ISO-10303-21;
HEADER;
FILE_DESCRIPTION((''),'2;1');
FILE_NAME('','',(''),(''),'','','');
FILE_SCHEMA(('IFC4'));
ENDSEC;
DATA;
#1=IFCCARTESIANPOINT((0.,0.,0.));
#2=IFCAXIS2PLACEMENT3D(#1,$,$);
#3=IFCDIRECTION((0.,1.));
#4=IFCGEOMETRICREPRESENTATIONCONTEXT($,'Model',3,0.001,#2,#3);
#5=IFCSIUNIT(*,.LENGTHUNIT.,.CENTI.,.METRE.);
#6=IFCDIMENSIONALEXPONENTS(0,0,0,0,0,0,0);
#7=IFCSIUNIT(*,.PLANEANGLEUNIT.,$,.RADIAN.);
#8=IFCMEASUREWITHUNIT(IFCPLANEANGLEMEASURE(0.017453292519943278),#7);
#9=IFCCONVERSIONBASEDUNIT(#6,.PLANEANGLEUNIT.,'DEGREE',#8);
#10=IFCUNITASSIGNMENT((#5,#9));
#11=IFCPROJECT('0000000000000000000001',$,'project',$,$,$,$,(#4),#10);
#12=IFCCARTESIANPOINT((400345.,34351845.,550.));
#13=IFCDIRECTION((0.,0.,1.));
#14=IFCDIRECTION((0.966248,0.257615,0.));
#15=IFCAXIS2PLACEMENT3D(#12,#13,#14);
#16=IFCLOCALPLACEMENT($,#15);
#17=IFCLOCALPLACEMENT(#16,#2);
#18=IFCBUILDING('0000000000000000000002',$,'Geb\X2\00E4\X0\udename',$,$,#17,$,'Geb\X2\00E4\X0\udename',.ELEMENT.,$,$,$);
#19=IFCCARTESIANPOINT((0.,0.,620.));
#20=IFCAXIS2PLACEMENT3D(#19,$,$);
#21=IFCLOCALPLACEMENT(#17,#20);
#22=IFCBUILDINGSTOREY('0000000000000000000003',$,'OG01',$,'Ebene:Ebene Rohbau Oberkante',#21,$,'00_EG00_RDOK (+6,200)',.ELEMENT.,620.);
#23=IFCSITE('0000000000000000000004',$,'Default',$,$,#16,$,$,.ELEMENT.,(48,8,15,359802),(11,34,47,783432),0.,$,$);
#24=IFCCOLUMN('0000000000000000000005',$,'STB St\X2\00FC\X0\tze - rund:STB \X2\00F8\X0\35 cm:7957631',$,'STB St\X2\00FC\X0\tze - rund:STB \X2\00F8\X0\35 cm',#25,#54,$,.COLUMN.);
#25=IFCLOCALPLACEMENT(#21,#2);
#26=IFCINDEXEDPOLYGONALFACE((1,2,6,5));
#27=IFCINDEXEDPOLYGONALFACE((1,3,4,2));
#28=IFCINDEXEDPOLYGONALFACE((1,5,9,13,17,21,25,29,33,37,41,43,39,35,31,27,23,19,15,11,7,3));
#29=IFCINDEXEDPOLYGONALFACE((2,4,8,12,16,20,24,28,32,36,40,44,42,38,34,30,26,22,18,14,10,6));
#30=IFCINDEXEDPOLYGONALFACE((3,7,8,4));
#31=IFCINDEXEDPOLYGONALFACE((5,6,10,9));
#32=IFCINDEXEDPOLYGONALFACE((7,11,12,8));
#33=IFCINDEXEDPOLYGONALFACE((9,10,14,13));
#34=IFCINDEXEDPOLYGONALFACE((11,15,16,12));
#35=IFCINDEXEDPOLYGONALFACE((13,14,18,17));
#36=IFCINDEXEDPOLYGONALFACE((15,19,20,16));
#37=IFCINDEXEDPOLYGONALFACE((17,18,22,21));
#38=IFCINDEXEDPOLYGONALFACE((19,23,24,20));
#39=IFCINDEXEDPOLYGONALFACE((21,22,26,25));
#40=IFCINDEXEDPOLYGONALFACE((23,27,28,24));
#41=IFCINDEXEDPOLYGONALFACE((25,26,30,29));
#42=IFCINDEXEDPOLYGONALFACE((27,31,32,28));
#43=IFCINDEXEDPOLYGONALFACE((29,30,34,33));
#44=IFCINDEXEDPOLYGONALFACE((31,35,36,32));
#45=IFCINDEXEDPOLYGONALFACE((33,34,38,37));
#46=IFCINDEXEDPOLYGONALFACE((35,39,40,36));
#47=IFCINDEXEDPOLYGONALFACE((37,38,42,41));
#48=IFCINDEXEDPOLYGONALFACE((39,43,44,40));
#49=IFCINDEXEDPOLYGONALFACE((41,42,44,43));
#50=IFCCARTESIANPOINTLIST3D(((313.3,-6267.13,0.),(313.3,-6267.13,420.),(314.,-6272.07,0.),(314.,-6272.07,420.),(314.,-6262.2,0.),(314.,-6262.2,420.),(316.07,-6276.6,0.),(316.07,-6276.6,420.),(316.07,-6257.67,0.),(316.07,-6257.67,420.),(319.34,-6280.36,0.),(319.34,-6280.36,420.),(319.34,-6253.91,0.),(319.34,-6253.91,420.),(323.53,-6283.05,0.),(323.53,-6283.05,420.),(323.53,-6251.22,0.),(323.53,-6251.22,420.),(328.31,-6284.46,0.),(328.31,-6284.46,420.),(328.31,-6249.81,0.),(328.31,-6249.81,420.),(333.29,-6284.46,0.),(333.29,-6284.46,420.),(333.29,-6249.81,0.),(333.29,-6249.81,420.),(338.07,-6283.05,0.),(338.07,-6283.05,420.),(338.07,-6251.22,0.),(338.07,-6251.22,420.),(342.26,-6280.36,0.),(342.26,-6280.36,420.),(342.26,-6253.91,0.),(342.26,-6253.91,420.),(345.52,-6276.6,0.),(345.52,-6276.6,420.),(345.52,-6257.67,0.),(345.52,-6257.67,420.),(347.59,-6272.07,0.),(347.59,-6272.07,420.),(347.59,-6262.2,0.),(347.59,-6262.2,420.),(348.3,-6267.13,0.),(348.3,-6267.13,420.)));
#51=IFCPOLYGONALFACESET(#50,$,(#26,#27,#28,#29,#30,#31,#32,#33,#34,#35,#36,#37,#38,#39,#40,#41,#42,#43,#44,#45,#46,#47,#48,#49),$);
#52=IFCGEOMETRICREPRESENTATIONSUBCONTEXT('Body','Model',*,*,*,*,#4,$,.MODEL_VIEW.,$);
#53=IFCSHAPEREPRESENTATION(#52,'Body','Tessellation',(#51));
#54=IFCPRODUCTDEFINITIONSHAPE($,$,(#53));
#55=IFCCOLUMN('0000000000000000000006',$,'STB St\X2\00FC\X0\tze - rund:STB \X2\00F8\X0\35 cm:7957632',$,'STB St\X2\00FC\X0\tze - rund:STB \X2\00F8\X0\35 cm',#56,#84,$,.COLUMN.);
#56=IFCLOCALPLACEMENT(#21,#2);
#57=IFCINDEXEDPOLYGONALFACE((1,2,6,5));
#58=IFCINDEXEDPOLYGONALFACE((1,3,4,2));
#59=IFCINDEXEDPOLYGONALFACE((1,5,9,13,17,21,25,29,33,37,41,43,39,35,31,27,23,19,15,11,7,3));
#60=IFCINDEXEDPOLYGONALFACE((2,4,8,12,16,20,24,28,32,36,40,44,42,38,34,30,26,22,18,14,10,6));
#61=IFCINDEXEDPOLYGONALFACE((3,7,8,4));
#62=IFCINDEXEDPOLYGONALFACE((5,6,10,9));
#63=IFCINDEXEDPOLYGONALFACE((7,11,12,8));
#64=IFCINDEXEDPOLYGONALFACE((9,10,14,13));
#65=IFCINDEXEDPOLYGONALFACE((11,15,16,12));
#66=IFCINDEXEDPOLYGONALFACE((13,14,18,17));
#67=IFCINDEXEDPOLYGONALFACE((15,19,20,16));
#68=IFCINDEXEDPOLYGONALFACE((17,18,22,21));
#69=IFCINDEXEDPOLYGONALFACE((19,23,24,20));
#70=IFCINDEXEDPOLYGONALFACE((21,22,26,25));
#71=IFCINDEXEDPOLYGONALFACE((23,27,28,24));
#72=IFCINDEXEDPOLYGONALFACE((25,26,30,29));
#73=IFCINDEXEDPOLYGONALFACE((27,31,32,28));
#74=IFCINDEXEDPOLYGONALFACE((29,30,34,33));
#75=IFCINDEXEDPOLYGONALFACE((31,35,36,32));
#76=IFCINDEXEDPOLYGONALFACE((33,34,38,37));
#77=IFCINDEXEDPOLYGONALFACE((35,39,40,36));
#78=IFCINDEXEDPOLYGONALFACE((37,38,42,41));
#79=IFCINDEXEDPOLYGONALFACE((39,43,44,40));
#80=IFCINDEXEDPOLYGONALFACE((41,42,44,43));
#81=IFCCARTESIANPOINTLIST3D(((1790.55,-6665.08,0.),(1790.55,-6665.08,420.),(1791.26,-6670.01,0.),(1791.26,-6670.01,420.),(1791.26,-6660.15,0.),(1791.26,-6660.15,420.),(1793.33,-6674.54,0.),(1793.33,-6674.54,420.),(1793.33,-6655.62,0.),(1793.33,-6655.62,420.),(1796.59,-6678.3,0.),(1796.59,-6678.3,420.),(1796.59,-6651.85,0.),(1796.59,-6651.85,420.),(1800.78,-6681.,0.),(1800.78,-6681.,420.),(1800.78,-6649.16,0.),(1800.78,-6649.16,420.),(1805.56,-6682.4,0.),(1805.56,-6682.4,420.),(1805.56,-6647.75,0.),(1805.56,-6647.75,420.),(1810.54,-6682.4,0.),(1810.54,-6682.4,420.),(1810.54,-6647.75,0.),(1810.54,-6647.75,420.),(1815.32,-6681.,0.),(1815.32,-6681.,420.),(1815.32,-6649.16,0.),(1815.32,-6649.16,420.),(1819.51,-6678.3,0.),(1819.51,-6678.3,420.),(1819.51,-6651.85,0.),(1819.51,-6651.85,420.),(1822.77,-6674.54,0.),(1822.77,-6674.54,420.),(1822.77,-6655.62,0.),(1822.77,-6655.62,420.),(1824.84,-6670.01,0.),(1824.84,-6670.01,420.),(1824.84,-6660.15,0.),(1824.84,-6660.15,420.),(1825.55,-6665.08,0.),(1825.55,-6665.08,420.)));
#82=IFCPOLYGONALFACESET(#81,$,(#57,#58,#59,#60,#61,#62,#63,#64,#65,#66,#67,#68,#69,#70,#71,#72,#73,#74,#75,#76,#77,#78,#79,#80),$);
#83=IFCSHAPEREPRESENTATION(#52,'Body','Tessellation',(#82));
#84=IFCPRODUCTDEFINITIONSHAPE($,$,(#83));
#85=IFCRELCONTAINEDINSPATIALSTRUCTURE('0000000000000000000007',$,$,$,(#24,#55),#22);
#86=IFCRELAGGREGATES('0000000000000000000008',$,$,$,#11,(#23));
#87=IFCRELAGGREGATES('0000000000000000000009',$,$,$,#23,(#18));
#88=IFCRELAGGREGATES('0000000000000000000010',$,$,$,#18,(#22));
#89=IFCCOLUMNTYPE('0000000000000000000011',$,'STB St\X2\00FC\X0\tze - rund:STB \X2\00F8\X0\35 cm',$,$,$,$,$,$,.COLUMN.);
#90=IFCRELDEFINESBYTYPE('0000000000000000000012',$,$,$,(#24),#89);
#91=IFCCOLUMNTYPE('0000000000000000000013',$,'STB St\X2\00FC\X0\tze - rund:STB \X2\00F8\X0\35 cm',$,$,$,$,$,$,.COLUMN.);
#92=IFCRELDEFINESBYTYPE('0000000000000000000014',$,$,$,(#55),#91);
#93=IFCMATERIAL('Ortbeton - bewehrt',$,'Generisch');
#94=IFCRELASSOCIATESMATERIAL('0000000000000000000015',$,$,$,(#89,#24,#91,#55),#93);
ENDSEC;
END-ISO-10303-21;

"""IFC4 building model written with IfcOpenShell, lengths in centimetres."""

from ifc_helpers import new_model, entity, si_unit, converted_unit, direction, frame, origin, place, context, subcontext, project, spatial, arc, indexed_curve, outline, extrude, source, transform, mapped, material, type_object, type_shapes, element, save


model = new_model("IFC4")

# Units and contexts
model_context = context("Model", 3, precision=0.001, world=origin(), true_north=direction((0.0, 1.0)))
body_context = subcontext(model_context, "Body", "Model", "MODEL_VIEW")
ifc_project = project(units=[si_unit("LENGTHUNIT", "METRE", prefix="CENTI"), converted_unit("PLANEANGLEUNIT", "DEGREE", entity("IfcPlaneAngleMeasure", 0.017453292519943278), si_unit("PLANEANGLEUNIT", "RADIAN"), dimensions=[0, 0, 0, 0, 0, 0, 0])], contexts=[model_context])

# Site, building, storey
site_placement = place(None, frame((400345.0, 34351845.0, 550.0), z_axis=(0.0, 0.0, 1.0), x_axis=(0.966248, 0.257615, 0.0)))
site = spatial("IfcSite", under=ifc_project, at=site_placement, Name="Default", CompositionType="ELEMENT", RefLatitude=(48, 8, 15, 359802), RefLongitude=(11, 34, 47, 783432), RefElevation=0.0)
building_placement = place(site_placement, origin())
building = spatial("IfcBuilding", under=site, at=building_placement, Name="Gebäudename", LongName="Gebäudename", CompositionType="ELEMENT")
storey_placement = place(building_placement, frame((0.0, 0.0, 620.0)))
storey = spatial("IfcBuildingStorey", under=building, at=storey_placement, Name="OG01", ObjectType="Ebene:Ebene Rohbau Oberkante", LongName="00_EG00_RDOK (+6,200)", CompositionType="ELEMENT", Elevation=620.0)

# Columns
ifc_material = material(Name="Ortbeton - bewehrt", Category="Generisch")
column_type_1 = type_object("IfcColumnType", Name="STB Stütze - rund:STB ø35 cm", PredefinedType="COLUMN", material=ifc_material)
shared_shape_1 = source(origin(), body_context, "Body", "SweptSolid", [
    extrude(outline(indexed_curve([(-17.5, 0.0), (0.0, -17.5), (17.5, 0.0), (0.0, 17.5)], segments=[arc(1, 2, 3), arc(3, 4, 1)], self_intersect=False)), frame((330.8, -6267.13, 620.0)), (0.0, 0.0, 1.0), 420.0),
])
type_shapes(column_type_1, [shared_shape_1])
column_1_placement = place(storey_placement, frame((0.0, 0.0, -620.0)))
element("IfcColumn", 1, at=column_1_placement, inside=storey, type_object=column_type_1, material=ifc_material, Name="STB Stütze - rund:STB ø35 cm:7957631", ObjectType="STB Stütze - rund:STB ø35 cm", PredefinedType="COLUMN", context=body_context, shape_type="MappedRepresentation", body=[
    mapped(shared_shape_1, transform((0.0, 0.0, 0.0), scale=1.0)),
])
column_type_2 = type_object("IfcColumnType", Name="STB Stütze - rund:STB ø35 cm", PredefinedType="COLUMN", material=ifc_material)
shared_shape_2 = source(origin(), body_context, "Body", "SweptSolid", [
    extrude(outline(indexed_curve([(-17.5, 0.0), (0.0, -17.5), (17.5, 0.0), (0.0, 17.5)], segments=[arc(1, 2, 3), arc(3, 4, 1)], self_intersect=False)), frame((1808.05, -6665.08, 620.0)), (0.0, 0.0, 1.0), 420.0),
])
type_shapes(column_type_2, [shared_shape_2])
column_2_placement = place(storey_placement, frame((0.0, 0.0, -620.0)))
element("IfcColumn", 2, at=column_2_placement, inside=storey, type_object=column_type_2, material=ifc_material, Name="STB Stütze - rund:STB ø35 cm:7957632", ObjectType="STB Stütze - rund:STB ø35 cm", PredefinedType="COLUMN", context=body_context, shape_type="MappedRepresentation", body=[
    mapped(shared_shape_2, transform((0.0, 0.0, 0.0), scale=1.0)),
])

save(model, "model.ifc")
